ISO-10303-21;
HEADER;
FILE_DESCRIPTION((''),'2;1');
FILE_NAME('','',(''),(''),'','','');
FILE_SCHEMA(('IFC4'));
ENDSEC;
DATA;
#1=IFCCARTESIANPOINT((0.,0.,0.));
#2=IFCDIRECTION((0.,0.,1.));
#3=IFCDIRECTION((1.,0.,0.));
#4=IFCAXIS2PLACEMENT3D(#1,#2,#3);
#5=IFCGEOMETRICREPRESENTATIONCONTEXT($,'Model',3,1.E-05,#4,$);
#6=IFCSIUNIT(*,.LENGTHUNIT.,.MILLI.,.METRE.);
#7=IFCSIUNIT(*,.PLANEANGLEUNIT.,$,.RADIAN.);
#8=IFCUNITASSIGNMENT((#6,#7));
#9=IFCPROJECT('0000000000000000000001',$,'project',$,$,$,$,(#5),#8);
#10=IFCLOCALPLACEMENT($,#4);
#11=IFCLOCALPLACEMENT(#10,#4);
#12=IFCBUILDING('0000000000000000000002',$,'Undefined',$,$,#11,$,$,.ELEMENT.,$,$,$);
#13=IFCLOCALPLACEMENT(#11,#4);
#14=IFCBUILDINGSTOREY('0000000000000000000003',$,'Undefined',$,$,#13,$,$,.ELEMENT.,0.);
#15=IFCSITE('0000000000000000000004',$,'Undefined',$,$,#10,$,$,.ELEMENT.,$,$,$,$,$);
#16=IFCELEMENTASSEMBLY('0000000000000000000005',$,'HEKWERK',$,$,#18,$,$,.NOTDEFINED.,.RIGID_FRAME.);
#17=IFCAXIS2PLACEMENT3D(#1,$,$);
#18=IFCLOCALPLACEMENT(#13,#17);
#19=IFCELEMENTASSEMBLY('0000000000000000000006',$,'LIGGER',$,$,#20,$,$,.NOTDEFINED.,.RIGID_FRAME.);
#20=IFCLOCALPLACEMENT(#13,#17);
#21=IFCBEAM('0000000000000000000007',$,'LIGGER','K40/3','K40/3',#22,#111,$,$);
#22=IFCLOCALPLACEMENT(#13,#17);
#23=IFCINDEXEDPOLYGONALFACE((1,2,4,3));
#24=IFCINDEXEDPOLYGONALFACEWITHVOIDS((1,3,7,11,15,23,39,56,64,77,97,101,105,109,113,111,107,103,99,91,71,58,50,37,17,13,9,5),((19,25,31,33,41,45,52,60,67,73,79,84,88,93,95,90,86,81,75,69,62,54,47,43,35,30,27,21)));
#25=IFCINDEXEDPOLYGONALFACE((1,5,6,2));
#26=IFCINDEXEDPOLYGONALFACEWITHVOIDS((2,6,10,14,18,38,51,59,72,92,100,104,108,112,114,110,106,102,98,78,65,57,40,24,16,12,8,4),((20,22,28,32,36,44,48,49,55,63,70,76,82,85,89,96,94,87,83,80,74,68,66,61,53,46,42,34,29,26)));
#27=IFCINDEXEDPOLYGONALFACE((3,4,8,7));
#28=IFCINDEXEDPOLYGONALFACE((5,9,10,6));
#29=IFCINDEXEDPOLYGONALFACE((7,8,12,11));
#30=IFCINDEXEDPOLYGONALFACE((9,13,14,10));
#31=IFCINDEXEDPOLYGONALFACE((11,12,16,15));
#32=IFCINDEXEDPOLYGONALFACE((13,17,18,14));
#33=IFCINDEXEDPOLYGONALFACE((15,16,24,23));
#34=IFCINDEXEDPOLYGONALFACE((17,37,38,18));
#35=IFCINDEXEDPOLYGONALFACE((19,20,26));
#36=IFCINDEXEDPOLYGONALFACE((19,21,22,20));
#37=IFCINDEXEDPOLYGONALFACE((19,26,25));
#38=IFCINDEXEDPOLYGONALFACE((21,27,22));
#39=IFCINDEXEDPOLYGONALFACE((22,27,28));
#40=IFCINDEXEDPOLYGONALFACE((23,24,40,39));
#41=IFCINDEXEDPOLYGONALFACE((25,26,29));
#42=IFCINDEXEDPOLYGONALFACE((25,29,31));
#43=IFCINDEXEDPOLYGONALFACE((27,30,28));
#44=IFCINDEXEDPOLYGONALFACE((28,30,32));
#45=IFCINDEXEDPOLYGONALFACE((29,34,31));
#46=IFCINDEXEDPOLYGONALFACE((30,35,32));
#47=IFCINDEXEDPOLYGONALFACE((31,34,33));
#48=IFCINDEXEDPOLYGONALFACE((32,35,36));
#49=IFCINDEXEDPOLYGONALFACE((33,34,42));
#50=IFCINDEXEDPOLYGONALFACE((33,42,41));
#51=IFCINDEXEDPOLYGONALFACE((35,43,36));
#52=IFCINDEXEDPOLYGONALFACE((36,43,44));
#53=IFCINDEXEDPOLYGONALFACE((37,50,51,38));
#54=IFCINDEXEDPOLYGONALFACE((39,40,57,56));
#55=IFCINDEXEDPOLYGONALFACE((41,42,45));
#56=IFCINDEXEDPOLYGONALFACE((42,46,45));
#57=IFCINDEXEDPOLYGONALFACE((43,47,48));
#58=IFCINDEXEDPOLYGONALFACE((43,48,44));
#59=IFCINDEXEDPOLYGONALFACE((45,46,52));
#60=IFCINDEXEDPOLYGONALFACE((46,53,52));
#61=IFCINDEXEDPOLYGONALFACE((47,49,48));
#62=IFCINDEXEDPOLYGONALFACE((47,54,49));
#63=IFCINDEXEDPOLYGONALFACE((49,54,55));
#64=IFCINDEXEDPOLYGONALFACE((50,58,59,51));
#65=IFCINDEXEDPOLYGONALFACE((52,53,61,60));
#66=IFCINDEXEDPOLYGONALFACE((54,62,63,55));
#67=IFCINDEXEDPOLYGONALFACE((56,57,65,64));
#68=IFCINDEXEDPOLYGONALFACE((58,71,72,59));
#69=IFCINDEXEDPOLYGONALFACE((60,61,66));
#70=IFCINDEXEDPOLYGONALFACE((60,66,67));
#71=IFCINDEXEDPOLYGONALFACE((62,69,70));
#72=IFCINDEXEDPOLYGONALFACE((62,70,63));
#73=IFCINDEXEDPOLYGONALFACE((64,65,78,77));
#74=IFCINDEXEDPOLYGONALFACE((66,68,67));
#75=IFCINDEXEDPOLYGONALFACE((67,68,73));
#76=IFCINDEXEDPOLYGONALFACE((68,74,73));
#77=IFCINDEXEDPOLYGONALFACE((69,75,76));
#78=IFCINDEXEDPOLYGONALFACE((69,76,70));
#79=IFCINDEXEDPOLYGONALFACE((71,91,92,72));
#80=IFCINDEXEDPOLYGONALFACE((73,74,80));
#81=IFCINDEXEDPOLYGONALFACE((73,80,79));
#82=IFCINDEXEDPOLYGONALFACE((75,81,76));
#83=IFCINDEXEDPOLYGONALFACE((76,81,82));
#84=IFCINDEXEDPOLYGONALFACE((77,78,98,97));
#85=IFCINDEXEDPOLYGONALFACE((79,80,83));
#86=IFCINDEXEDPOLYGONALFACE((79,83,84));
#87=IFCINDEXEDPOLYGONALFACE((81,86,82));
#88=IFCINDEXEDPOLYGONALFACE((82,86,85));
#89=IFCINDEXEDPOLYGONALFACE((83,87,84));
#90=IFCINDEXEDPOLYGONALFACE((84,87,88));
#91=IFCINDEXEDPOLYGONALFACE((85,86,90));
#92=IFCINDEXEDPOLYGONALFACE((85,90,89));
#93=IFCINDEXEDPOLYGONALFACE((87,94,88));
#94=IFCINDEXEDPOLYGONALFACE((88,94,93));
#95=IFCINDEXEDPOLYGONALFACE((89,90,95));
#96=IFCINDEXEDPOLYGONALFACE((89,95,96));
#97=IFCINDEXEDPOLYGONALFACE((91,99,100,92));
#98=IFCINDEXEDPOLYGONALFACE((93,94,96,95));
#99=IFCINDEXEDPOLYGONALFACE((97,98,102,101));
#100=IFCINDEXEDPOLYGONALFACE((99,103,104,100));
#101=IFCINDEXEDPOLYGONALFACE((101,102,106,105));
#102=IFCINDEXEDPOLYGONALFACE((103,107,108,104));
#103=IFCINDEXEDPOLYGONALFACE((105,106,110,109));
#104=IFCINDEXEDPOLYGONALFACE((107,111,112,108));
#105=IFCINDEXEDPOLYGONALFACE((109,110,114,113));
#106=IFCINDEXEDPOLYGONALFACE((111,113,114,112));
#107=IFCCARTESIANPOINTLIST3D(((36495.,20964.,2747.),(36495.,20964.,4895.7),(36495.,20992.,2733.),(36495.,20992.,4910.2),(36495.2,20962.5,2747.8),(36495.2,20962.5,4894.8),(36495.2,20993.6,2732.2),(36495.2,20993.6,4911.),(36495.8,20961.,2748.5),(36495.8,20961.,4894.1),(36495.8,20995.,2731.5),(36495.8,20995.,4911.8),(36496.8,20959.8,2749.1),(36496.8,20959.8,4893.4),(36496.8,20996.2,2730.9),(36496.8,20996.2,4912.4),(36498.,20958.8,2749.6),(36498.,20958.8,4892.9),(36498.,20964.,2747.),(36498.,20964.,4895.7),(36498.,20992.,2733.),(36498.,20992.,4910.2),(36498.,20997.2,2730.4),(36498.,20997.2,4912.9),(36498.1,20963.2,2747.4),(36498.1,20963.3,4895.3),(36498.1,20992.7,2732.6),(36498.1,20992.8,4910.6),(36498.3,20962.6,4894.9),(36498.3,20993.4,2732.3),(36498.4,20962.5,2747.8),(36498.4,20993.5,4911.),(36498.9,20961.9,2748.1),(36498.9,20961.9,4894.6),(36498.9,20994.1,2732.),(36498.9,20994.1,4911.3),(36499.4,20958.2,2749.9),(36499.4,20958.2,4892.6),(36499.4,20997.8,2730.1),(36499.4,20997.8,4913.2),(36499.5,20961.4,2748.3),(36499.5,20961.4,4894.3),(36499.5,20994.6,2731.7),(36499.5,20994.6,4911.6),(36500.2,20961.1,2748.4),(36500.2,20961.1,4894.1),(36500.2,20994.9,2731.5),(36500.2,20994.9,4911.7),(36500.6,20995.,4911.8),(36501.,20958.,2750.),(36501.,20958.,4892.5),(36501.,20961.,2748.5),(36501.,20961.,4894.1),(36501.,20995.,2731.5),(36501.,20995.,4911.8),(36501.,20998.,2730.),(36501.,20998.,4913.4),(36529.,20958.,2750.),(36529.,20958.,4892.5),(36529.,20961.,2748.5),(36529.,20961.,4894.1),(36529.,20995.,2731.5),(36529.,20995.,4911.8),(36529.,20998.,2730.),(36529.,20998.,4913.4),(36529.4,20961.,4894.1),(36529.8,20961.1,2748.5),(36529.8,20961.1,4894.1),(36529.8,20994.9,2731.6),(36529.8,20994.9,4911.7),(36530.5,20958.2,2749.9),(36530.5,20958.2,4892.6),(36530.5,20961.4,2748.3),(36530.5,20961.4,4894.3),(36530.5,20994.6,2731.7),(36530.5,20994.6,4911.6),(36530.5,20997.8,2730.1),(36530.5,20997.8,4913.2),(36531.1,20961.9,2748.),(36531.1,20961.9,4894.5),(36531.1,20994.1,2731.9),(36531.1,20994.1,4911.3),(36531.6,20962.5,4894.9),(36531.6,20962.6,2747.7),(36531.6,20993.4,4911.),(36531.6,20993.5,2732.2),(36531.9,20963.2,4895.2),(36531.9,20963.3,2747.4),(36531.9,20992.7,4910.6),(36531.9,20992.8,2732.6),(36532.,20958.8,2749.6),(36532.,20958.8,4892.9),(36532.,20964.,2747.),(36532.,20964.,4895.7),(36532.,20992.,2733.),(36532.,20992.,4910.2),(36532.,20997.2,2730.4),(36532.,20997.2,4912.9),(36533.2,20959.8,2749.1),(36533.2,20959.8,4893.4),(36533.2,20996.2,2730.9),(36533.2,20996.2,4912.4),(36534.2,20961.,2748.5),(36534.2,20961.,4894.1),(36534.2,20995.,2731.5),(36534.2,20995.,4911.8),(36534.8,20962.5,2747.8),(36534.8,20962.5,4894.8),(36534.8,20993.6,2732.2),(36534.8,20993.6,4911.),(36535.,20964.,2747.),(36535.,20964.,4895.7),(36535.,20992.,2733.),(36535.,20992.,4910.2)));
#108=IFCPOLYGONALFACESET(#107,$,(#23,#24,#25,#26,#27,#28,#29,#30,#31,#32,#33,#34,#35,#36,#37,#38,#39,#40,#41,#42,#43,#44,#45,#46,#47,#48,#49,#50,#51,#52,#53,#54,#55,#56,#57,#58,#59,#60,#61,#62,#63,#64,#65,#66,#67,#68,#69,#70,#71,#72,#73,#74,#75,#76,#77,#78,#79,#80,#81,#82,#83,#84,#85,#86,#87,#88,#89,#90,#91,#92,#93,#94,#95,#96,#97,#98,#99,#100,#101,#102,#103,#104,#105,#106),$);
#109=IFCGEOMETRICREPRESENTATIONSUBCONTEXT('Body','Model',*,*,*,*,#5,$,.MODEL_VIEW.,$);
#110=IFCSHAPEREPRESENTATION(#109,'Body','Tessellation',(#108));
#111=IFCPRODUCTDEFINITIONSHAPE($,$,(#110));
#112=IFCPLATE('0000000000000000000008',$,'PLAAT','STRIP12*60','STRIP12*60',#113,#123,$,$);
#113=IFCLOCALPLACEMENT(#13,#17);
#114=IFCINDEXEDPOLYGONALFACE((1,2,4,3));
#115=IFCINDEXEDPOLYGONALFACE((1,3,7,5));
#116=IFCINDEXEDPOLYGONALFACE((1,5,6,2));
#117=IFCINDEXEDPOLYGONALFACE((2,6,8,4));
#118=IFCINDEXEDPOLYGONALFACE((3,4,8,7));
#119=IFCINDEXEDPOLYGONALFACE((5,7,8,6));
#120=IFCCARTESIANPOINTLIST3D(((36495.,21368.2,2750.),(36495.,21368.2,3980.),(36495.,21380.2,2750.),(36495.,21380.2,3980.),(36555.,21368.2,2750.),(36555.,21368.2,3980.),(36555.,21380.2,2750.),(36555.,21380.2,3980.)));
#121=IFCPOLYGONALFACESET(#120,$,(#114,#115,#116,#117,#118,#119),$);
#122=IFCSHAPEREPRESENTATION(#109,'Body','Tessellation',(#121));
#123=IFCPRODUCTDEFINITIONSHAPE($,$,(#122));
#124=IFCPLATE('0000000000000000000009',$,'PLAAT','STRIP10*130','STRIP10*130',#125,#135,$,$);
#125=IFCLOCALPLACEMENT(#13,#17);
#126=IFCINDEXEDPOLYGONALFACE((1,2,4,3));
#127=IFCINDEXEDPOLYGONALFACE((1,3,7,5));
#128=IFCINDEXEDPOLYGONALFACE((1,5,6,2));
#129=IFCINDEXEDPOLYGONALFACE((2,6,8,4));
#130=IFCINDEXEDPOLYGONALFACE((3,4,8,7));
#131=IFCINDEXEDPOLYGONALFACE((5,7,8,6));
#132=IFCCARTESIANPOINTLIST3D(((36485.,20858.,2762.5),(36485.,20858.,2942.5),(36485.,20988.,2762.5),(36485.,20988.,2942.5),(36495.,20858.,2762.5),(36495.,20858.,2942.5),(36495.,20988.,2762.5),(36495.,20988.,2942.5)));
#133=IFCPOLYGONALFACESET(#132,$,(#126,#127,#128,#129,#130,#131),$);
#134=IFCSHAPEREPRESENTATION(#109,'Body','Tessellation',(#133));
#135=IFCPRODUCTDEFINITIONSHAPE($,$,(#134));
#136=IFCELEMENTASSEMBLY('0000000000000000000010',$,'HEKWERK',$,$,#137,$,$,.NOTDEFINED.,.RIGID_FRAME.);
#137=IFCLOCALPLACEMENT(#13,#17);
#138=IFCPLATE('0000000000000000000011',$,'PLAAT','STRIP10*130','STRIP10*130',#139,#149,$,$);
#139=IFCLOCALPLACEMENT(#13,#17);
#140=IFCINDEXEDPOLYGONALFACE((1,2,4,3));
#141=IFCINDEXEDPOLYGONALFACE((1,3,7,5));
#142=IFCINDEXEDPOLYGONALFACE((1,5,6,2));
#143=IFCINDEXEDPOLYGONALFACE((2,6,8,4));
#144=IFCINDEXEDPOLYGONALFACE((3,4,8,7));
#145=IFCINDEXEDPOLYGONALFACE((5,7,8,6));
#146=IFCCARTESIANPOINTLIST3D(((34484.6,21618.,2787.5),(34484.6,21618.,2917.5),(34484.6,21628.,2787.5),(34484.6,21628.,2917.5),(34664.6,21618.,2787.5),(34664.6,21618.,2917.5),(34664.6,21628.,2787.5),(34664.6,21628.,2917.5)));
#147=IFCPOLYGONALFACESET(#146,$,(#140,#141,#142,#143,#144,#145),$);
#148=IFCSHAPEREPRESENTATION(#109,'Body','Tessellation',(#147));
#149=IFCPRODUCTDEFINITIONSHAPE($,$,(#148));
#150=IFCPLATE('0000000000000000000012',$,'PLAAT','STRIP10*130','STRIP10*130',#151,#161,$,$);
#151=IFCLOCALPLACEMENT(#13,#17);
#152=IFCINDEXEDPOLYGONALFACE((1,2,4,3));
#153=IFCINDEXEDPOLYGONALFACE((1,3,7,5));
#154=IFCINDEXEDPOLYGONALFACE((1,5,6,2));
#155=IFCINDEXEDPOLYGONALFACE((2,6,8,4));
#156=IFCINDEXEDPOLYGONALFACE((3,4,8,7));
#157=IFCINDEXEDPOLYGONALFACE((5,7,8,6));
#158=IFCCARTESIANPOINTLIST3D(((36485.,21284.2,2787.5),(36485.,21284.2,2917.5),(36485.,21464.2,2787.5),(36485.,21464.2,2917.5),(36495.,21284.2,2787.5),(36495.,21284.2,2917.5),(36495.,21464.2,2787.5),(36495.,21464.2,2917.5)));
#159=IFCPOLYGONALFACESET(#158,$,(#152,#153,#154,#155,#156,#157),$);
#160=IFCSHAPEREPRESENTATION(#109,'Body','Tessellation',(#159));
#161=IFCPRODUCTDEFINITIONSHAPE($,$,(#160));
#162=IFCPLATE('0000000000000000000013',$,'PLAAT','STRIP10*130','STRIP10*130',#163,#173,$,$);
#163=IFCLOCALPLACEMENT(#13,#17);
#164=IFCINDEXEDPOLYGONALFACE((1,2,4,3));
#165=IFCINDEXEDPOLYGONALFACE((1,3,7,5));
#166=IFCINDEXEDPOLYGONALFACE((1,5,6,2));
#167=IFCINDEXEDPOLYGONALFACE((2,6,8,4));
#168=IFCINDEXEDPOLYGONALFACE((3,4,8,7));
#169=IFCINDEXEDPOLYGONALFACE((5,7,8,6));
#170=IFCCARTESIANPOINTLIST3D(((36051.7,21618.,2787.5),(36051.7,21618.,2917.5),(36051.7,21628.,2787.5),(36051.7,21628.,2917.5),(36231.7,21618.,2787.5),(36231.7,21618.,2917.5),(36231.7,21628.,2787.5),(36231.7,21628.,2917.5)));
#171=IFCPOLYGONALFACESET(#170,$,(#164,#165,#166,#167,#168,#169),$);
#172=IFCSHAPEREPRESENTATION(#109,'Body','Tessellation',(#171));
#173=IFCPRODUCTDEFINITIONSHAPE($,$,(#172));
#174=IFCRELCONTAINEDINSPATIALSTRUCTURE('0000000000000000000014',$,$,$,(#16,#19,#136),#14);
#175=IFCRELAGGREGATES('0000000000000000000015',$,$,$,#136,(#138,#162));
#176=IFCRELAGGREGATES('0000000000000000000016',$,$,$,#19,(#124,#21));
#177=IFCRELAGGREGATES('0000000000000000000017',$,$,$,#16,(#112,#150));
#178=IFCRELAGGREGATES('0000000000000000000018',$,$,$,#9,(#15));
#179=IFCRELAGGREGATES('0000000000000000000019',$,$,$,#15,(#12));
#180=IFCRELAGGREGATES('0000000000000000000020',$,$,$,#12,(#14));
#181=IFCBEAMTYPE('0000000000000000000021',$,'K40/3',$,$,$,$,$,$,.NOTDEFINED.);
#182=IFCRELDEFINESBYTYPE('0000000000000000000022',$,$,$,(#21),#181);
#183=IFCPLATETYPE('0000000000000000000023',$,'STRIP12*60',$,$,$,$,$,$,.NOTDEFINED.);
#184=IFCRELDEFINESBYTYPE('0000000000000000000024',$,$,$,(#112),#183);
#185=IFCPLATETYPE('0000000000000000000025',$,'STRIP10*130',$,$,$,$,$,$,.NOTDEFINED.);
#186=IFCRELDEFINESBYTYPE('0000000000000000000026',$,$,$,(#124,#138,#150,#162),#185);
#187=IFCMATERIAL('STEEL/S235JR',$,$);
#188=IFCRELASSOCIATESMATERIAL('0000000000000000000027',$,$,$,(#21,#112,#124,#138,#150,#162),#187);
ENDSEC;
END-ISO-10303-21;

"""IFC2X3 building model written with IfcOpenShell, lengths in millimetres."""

from ifc_helpers import new_model, si_unit, frame, origin_with_axes, origin_2d_with_axis, place, context, subcontext, project, spatial, rectangle, hollow_rectangle, extrude, clip, halfspace, material, type_object, element, aggregate, save


model = new_model("IFC2X3")

# Units and contexts
model_context = context("Model", 3, precision=1e-05, world=origin_with_axes())
body_context = subcontext(model_context, "Body", "Model", "MODEL_VIEW")
ifc_project = project(units=[si_unit("LENGTHUNIT", "METRE", prefix="MILLI"), si_unit("PLANEANGLEUNIT", "RADIAN")], contexts=[model_context])

# Site, building, storey
site_placement = place(None, origin_with_axes())
site = spatial("IfcSite", under=ifc_project, at=site_placement, Name="Undefined", CompositionType="ELEMENT")
building_placement = place(site_placement, origin_with_axes())
building = spatial("IfcBuilding", under=site, at=building_placement, Name="Undefined", CompositionType="ELEMENT")
storey_placement = place(building_placement, origin_with_axes())
storey = spatial("IfcBuildingStorey", under=building, at=storey_placement, Name="Undefined", CompositionType="ELEMENT", Elevation=0.0)

# Element assemblies, beam
assembly_1_placement = place(storey_placement, origin_with_axes())
assembly_1 = element("IfcElementAssembly", 1, at=assembly_1_placement, inside=storey, Name="HEKWERK", AssemblyPlace="NOTDEFINED", PredefinedType="RIGID_FRAME")
ifc_material_1 = material(Name="STEEL/S235JR")
assembly_2_placement = place(storey_placement, origin_with_axes())
assembly_2 = element("IfcElementAssembly", 2, at=assembly_2_placement, inside=storey, Name="LIGGER", AssemblyPlace="NOTDEFINED", PredefinedType="RIGID_FRAME")
beam_type_1 = type_object("IfcBeamType", Name="K40/3", PredefinedType="NOTDEFINED")
beam_1_placement = place(assembly_2_placement, frame((36515.0, 20978.0, 4933.4), z_axis=(1.0, 0.0, 0.0), x_axis=(0.0, 0.000002, -1.0)))
beam_1 = element("IfcBeam", 3, at=beam_1_placement, type_object=beam_type_1, material=ifc_material_1, Name="LIGGER", Description="K40/3", ObjectType="K40/3", context=body_context, shape_type="Clipping", body=[
    clip(clip(extrude(hollow_rectangle(XDim=40.0, YDim=40.0, WallThickness=3.0, InnerFilletRadius=3.0, OuterFilletRadius=6.0, at=origin_2d_with_axis()), frame((2214.0, 0.0, 0.0), z_axis=(-1.0, 0.0, 0.0), x_axis=(0.0, -1.0, 0.0)), (0.0, 0.0, 1.0), 2204.2), halfspace(frame((2183.4, -20.0, 0.0), z_axis=(-0.894427, 0.447215, 0.0), x_axis=(0.0, 0.0, -1.0)), True)), halfspace(frame((20.0, 20.0, 0.0), z_axis=(0.887011, 0.461748, 0.0), x_axis=(0.0, 0.0, -1.0)), True)),
])

# Plates
plate_type_1 = type_object("IfcPlateType", Name="STRIP12*60", PredefinedType="NOTDEFINED")
plate_1_placement = place(assembly_1_placement, frame((36525.0, 21374.2, 3980.0), z_axis=(-1.0, 0.0, 0.0), x_axis=(0.0, 0.0, -1.0)))
plate_1 = element("IfcPlate", 4, at=plate_1_placement, type_object=plate_type_1, material=ifc_material_1, Name="PLAAT", Description="STRIP12*60", ObjectType="STRIP12*60", context=body_context, shape_type="SweptSolid", body=[
    extrude(rectangle(XDim=12.0, YDim=60.0, at=origin_2d_with_axis()), frame((1230.0, 0.0, 0.0), z_axis=(-1.0, 0.0, 0.0), x_axis=(0.0, -1.0, 0.0)), (0.0, 0.0, 1.0), 1230.0),
])
plate_type_2 = type_object("IfcPlateType", Name="STRIP10*130", PredefinedType="NOTDEFINED")
plate_2_placement = place(assembly_2_placement, frame((36490.0, 20923.0, 2942.5), z_axis=(0.0, -1.0, -0.000002), x_axis=(0.0, 0.000002, -1.0)))
plate_2 = element("IfcPlate", 5, at=plate_2_placement, type_object=plate_type_2, material=ifc_material_1, Name="PLAAT", Description="STRIP10*130", ObjectType="STRIP10*130", context=body_context, shape_type="SweptSolid", body=[
    extrude(rectangle(XDim=10.0, YDim=130.0, at=origin_2d_with_axis()), frame((180.0, 0.0, 0.0), z_axis=(-1.0, 0.0, 0.0), x_axis=(0.0, -1.0, 0.0)), (0.0, 0.0, 1.0), 180.0),
])

# Element assembly, plate
assembly_3_placement = place(storey_placement, origin_with_axes())
assembly_3 = element("IfcElementAssembly", 6, at=assembly_3_placement, inside=storey, Name="HEKWERK", AssemblyPlace="NOTDEFINED", PredefinedType="RIGID_FRAME")
plate_3_placement = place(assembly_3_placement, frame((34664.6, 21623.0, 2852.5), z_axis=(0.0, 0.0, 1.0), x_axis=(-1.0, 0.0, 0.0)))
plate_3 = element("IfcPlate", 7, at=plate_3_placement, type_object=plate_type_2, material=ifc_material_1, Name="PLAAT", Description="STRIP10*130", ObjectType="STRIP10*130", context=body_context, shape_type="SweptSolid", body=[
    extrude(rectangle(XDim=10.0, YDim=130.0, at=origin_2d_with_axis()), frame((180.0, 0.0, 0.0), z_axis=(-1.0, 0.0, 0.0), x_axis=(0.0, -1.0, 0.0)), (0.0, 0.0, 1.0), 180.0),
])

# Plates
plate_4_placement = place(assembly_1_placement, frame((36490.0, 21464.2, 2852.5), z_axis=(0.0, 0.0, 1.0), x_axis=(0.0, -1.0, 0.0)))
plate_4 = element("IfcPlate", 8, at=plate_4_placement, type_object=plate_type_2, material=ifc_material_1, Name="PLAAT", Description="STRIP10*130", ObjectType="STRIP10*130", context=body_context, shape_type="SweptSolid", body=[
    extrude(rectangle(XDim=10.0, YDim=130.0, at=origin_2d_with_axis()), frame((180.0, 0.0, 0.0), z_axis=(-1.0, 0.0, 0.0), x_axis=(0.0, -1.0, 0.0)), (0.0, 0.0, 1.0), 180.0),
])
plate_5_placement = place(assembly_3_placement, frame((36231.7, 21623.0, 2852.5), z_axis=(0.0, 0.0, 1.0), x_axis=(-1.0, 0.0, 0.0)))
plate_5 = element("IfcPlate", 9, at=plate_5_placement, type_object=plate_type_2, material=ifc_material_1, Name="PLAAT", Description="STRIP10*130", ObjectType="STRIP10*130", context=body_context, shape_type="SweptSolid", body=[
    extrude(rectangle(XDim=10.0, YDim=130.0, at=origin_2d_with_axis()), frame((180.0, 0.0, 0.0), z_axis=(-1.0, 0.0, 0.0), x_axis=(0.0, -1.0, 0.0)), (0.0, 0.0, 1.0), 180.0),
])
aggregate(assembly_3, [plate_3, plate_5])

aggregate(assembly_2, [plate_2, beam_1])
aggregate(assembly_1, [plate_1, plate_4])

save(model, "model.ifc")
